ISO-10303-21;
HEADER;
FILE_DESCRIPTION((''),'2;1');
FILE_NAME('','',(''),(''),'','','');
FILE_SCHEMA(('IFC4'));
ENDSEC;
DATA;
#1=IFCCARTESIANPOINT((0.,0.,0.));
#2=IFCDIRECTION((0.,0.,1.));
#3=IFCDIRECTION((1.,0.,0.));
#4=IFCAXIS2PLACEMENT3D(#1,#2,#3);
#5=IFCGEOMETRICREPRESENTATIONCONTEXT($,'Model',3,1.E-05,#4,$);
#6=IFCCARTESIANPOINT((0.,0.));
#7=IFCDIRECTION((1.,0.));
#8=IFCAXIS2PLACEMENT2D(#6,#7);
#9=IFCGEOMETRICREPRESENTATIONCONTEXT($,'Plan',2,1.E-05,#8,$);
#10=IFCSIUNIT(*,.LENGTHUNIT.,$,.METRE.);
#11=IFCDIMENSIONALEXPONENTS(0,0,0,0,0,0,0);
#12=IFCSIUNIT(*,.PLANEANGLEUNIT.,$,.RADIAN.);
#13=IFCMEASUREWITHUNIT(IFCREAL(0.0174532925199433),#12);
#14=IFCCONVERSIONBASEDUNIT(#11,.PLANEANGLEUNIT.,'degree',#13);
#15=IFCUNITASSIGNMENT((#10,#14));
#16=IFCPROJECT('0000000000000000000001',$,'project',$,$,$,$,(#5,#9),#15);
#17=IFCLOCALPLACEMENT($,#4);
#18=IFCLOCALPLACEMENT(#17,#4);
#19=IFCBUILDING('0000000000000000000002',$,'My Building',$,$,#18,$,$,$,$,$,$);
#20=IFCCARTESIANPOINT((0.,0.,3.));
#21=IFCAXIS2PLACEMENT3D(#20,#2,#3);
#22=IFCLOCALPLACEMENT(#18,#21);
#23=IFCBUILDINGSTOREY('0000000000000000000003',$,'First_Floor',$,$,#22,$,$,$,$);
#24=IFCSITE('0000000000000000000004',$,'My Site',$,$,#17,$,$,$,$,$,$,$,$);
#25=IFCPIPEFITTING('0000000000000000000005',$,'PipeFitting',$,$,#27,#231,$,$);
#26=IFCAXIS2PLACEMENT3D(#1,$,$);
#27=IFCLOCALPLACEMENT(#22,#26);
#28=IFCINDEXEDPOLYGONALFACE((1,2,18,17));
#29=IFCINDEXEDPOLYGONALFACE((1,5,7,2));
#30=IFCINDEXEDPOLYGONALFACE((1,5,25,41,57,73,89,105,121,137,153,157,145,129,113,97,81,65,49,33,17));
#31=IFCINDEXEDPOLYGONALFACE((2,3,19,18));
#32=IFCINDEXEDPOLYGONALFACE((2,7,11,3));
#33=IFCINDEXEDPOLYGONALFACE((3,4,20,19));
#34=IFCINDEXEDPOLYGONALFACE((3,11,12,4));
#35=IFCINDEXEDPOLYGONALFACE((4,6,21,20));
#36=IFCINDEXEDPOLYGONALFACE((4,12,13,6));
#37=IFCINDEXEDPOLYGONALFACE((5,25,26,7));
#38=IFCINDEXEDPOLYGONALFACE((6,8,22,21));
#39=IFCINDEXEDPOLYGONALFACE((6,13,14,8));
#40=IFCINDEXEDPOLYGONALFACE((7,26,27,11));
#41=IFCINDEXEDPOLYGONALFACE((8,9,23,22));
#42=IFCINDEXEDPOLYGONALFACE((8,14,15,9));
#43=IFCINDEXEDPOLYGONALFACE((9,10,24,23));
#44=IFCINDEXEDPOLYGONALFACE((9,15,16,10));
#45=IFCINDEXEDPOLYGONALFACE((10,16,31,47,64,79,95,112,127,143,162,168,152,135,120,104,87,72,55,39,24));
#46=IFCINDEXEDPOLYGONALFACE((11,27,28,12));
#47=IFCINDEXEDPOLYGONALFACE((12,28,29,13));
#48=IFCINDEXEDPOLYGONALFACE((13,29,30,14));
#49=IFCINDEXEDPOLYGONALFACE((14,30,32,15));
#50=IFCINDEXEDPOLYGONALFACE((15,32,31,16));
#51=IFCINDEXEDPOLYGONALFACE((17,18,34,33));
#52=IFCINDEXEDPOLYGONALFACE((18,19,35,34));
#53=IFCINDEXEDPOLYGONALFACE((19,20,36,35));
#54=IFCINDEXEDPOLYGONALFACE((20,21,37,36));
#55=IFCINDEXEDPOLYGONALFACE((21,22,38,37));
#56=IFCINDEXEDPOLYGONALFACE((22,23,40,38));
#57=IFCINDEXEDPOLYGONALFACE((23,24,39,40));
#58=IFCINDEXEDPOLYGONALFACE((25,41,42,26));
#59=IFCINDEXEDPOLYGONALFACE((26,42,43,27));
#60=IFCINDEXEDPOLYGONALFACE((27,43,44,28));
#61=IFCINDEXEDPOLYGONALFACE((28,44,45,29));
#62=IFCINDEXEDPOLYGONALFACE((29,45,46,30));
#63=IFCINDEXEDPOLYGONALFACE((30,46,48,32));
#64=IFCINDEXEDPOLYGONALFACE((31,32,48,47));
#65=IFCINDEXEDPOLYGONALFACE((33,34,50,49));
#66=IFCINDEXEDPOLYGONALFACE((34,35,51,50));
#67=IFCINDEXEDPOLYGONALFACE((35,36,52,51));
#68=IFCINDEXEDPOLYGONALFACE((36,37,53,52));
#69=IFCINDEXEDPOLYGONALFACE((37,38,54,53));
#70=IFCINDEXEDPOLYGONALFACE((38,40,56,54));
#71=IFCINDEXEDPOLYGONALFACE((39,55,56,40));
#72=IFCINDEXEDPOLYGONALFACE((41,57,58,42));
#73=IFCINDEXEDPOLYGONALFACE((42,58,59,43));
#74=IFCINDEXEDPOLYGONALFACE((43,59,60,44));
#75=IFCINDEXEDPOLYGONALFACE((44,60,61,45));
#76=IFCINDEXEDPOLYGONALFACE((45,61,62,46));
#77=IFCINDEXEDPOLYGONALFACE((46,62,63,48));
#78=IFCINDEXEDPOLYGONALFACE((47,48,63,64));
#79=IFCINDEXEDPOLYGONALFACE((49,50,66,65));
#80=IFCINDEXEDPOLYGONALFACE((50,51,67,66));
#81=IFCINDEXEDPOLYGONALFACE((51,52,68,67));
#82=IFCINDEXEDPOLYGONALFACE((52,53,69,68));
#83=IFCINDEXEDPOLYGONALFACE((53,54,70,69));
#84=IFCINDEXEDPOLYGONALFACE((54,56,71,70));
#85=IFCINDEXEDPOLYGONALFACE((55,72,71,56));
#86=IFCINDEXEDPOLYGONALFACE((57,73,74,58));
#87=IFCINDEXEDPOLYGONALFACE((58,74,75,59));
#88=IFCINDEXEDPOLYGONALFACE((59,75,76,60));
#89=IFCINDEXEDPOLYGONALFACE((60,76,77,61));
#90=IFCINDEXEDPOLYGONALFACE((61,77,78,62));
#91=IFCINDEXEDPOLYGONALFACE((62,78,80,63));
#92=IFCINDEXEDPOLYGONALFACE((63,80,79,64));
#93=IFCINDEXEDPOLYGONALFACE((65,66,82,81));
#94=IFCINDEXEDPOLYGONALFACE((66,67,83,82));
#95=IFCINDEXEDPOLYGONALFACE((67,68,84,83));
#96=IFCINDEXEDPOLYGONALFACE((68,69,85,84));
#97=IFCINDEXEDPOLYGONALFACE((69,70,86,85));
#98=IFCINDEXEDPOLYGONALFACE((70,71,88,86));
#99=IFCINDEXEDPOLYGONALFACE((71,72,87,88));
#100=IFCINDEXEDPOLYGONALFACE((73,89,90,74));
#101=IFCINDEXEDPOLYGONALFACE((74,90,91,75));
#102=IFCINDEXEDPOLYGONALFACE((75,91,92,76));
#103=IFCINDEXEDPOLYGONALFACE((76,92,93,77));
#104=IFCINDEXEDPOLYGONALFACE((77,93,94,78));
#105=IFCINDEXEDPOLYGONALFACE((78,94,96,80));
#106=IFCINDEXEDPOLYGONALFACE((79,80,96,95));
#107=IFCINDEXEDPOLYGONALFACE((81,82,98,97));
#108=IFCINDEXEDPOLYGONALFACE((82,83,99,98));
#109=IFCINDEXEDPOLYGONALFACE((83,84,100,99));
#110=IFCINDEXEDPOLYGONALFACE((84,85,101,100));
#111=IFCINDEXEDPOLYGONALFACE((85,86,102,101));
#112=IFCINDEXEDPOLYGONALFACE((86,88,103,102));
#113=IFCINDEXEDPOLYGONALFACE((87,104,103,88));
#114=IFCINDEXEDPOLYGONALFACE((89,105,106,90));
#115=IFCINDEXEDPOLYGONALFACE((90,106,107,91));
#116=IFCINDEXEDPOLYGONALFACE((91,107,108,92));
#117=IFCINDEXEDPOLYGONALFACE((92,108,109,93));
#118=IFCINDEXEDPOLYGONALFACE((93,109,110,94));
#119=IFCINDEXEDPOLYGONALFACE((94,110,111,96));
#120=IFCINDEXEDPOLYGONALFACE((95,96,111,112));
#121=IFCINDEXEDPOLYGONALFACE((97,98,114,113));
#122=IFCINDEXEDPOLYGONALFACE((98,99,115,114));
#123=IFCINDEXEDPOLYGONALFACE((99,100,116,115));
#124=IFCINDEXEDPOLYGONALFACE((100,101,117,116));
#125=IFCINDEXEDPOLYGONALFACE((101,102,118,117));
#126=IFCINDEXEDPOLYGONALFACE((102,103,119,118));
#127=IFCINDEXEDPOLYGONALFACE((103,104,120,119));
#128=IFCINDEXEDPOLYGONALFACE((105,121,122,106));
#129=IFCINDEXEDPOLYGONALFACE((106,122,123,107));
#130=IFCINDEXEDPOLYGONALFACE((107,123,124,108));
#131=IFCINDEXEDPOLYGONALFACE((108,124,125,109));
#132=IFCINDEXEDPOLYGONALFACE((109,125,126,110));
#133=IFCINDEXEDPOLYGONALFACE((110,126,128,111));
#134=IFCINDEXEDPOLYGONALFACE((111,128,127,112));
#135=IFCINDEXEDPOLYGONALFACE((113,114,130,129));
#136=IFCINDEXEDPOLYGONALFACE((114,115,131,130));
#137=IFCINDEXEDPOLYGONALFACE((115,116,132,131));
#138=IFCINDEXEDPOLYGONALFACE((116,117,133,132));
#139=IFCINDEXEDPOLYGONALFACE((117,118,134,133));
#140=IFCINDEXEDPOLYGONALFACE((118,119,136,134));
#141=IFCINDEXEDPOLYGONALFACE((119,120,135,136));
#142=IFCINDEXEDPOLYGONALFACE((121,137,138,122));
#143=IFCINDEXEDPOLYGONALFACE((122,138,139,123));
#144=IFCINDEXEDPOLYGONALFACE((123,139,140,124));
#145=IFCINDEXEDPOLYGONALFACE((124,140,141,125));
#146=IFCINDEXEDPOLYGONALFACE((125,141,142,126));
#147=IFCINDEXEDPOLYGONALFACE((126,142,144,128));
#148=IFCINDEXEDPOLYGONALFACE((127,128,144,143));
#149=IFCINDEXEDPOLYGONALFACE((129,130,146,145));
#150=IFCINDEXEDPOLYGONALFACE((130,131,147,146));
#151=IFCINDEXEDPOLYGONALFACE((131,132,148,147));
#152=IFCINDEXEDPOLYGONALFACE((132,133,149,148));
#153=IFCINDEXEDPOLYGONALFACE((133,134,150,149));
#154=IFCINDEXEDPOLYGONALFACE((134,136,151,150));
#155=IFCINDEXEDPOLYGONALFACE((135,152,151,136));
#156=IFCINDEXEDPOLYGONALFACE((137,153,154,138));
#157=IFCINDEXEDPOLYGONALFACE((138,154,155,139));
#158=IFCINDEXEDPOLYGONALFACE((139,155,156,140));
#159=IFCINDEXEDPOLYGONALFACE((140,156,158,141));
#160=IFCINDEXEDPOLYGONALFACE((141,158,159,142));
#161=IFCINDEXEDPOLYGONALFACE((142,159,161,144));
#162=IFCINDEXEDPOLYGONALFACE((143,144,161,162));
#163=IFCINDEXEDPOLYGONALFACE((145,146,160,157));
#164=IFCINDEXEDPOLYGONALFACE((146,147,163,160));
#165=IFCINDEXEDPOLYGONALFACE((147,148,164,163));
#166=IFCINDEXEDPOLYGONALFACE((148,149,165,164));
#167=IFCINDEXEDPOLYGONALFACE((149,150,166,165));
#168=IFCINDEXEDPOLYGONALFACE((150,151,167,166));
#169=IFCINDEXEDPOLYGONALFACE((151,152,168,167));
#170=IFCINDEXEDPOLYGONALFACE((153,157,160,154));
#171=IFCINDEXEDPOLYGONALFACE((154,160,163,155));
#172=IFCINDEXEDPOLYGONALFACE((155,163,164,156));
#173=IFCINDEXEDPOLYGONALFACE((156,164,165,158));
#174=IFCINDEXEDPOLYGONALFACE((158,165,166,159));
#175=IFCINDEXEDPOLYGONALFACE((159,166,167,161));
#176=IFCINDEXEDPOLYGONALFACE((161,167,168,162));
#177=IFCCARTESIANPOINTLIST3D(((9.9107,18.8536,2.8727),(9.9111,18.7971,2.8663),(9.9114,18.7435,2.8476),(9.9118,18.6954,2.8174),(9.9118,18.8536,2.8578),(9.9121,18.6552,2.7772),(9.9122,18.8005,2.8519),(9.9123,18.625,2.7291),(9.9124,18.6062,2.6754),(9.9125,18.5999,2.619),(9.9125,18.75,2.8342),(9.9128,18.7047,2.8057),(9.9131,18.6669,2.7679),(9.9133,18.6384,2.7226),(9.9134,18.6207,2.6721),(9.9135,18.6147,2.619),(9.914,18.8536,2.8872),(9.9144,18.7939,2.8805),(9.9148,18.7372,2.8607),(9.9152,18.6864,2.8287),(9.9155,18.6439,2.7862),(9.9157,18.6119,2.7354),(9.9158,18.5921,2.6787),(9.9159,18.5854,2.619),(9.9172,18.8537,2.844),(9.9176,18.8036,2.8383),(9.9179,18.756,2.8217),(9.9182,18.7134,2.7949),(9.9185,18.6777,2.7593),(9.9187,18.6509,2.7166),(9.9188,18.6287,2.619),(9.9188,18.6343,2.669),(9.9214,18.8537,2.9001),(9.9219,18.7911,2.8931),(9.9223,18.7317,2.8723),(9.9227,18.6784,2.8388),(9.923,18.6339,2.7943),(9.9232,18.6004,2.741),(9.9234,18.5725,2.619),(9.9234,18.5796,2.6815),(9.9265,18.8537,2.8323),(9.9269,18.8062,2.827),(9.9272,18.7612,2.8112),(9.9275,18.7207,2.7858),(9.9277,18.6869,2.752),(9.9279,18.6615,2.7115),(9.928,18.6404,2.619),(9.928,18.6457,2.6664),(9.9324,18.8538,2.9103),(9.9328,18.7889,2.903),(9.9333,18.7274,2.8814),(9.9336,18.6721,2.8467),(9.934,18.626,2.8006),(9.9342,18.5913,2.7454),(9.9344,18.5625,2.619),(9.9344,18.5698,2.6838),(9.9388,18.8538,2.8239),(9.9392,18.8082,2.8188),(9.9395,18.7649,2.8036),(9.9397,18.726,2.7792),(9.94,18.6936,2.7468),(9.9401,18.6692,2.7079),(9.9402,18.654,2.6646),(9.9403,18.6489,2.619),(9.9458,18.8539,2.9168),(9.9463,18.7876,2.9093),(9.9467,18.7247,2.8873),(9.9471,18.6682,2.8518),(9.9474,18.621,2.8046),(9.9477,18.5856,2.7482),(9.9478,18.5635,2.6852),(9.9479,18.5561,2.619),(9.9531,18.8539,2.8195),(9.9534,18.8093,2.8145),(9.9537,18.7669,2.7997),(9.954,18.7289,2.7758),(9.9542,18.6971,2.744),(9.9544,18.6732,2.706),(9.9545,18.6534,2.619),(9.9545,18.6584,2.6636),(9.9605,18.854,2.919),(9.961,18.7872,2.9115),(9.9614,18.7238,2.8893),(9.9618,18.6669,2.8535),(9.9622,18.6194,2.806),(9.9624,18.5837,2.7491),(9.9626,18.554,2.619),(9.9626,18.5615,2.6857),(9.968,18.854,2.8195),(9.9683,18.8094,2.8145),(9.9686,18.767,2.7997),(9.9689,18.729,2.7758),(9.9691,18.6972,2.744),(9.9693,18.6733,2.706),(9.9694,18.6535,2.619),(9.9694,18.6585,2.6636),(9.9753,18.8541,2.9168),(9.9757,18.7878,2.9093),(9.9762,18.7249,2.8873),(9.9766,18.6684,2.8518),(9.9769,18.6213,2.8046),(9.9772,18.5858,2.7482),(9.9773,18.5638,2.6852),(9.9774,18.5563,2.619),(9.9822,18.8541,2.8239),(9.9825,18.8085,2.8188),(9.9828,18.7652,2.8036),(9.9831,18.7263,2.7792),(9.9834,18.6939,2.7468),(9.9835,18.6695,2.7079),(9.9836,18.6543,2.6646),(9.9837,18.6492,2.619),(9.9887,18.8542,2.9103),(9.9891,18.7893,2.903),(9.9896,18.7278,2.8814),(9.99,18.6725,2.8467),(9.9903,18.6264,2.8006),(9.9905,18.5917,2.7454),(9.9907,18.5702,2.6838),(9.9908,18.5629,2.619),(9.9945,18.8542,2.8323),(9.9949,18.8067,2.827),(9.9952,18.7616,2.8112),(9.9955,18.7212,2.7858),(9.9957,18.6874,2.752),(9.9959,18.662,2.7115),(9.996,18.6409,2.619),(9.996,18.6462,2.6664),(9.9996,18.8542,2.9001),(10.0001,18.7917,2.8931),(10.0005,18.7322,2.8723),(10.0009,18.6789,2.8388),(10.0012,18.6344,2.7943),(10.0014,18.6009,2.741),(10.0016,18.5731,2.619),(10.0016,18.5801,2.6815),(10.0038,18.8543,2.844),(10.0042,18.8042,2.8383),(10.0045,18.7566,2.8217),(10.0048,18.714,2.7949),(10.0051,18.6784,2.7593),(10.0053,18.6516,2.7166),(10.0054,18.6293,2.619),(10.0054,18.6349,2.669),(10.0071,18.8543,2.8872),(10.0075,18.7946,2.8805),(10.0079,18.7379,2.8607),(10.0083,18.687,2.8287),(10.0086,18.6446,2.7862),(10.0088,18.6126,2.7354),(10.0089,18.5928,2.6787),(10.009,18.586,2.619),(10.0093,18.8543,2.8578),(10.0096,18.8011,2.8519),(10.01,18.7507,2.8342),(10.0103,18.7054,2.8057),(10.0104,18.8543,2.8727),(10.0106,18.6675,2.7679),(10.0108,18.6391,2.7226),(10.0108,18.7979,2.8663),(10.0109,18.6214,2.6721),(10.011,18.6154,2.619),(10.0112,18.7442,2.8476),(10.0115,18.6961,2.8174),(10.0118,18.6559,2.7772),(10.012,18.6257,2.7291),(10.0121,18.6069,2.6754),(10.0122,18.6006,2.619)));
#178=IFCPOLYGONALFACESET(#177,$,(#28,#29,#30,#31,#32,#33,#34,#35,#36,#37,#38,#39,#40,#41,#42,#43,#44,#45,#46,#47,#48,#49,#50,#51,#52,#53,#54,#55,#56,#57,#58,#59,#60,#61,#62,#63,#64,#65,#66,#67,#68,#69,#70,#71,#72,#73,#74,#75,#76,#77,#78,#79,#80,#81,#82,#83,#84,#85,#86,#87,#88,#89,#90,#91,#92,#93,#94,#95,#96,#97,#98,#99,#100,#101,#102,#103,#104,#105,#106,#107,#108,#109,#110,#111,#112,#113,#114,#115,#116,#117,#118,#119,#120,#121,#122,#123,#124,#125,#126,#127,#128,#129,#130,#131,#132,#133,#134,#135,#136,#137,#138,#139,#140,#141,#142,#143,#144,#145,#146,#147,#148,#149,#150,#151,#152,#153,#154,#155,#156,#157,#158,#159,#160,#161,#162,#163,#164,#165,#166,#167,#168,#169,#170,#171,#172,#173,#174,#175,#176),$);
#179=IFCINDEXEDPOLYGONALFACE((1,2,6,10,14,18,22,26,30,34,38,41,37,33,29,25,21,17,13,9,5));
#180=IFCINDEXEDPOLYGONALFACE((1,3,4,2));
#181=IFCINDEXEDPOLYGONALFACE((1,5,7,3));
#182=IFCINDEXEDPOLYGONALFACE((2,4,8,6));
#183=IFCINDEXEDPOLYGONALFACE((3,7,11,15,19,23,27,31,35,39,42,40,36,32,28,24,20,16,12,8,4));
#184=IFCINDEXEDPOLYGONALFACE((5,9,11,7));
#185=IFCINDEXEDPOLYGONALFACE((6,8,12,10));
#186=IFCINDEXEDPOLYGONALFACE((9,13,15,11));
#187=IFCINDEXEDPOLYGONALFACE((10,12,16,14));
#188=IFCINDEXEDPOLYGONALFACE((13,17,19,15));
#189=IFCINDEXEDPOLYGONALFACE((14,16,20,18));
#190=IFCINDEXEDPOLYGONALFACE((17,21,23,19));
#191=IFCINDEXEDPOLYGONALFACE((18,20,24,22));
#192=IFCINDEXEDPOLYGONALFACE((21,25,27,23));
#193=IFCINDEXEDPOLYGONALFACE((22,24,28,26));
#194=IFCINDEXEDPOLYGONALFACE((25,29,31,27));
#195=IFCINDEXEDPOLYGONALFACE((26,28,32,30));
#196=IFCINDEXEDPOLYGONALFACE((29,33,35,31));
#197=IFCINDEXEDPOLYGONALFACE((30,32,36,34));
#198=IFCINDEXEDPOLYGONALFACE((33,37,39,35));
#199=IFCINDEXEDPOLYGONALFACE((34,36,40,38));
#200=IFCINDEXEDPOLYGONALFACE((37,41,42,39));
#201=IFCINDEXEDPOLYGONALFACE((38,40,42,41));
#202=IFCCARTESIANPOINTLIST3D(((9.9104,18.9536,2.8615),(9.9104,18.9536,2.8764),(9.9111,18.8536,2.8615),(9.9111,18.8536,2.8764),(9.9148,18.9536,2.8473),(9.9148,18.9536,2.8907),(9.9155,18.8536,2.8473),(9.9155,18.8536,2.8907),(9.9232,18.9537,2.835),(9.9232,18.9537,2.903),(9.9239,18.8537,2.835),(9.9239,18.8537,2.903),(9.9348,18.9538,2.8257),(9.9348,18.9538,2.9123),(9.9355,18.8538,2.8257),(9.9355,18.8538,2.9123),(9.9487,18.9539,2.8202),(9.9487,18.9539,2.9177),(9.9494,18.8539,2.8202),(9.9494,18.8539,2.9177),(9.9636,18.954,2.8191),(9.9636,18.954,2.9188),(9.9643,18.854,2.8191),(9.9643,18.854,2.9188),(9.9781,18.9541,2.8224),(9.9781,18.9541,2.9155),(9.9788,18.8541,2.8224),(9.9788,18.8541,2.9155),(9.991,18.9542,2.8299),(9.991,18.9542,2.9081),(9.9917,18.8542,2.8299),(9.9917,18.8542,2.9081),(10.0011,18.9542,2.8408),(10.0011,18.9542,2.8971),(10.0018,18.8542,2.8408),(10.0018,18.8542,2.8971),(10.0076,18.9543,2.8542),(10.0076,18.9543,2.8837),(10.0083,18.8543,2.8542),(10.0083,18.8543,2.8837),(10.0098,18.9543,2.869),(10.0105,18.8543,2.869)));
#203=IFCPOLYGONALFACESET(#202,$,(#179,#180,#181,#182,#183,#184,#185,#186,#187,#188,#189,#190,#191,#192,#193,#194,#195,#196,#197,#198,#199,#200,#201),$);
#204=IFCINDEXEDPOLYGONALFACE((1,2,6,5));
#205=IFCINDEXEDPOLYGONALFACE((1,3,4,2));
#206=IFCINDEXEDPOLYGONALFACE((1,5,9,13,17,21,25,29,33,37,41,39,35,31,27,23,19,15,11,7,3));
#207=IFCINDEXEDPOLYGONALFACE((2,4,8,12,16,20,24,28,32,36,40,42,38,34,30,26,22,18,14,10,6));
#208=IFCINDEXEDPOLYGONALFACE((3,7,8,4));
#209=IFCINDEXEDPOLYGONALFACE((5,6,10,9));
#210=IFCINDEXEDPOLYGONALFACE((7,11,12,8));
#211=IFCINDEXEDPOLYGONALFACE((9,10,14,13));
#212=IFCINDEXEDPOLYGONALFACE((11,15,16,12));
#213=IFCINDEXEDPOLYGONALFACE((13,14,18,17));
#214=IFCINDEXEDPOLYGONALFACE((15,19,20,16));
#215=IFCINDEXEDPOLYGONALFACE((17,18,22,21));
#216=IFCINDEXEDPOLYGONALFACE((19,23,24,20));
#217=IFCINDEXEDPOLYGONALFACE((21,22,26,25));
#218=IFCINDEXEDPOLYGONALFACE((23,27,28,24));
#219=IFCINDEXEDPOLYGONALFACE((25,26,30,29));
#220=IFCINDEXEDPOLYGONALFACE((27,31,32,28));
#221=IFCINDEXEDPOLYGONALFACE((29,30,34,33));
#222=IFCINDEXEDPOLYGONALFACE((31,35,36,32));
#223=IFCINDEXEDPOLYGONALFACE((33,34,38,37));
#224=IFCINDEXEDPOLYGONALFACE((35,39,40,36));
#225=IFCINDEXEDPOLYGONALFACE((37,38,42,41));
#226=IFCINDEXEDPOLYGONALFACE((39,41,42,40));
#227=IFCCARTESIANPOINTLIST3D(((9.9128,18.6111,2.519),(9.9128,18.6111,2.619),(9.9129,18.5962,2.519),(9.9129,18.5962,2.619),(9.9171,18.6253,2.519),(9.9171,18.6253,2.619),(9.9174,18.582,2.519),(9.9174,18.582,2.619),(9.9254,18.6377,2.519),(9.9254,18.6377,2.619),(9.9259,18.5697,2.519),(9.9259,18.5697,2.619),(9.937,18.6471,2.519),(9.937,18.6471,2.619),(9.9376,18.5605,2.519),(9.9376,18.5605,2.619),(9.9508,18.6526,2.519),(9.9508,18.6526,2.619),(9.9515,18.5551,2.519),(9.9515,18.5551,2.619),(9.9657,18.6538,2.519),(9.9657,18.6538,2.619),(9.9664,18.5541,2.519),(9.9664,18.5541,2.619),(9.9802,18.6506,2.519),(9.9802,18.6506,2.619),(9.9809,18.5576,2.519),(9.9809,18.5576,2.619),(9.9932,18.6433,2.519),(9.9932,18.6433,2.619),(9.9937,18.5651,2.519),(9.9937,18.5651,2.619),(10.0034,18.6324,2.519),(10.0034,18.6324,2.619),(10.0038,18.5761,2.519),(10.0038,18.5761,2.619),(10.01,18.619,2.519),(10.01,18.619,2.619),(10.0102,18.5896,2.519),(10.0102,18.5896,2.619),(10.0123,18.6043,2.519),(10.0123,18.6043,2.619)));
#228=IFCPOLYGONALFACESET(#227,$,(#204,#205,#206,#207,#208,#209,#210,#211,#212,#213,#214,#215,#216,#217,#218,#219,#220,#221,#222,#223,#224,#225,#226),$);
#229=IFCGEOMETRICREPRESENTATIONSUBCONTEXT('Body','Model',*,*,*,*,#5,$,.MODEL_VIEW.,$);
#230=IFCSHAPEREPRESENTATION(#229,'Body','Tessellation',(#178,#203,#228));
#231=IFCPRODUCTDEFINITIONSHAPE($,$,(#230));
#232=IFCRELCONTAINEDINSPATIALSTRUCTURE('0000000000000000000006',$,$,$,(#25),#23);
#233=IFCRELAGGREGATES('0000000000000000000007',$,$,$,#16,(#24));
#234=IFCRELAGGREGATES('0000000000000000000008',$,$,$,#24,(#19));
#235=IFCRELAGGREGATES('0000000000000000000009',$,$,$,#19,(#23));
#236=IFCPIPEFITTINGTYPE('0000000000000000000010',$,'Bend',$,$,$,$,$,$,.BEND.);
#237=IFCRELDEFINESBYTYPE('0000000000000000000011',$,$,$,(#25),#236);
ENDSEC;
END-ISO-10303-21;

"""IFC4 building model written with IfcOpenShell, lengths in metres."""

from ifc_helpers import new_model, entity, si_unit, converted_unit, frame, origin_with_axes, origin_2d_with_axis, place, context, subcontext, project, spatial, circle, extrude, source, transform, mapped, type_object, type_shapes, element, save


model = new_model("IFC4")

# Units and contexts
model_context = context("Model", 3, precision=1e-05, world=origin_with_axes())
plan_context = context("Plan", 2, precision=1e-05, world=origin_2d_with_axis())
body_context_1 = subcontext(model_context, "Body", "Model", "MODEL_VIEW")
ifc_project = project(units=[si_unit("LENGTHUNIT", "METRE"), converted_unit("PLANEANGLEUNIT", "degree", entity("IfcReal", 0.0174532925199433), si_unit("PLANEANGLEUNIT", "RADIAN"), dimensions=[0, 0, 0, 0, 0, 0, 0])], contexts=[model_context, plan_context])

# Site, building, storey
site_placement = place(None, origin_with_axes())
site = spatial("IfcSite", under=ifc_project, at=site_placement, Name="My Site")
building_placement = place(site_placement, origin_with_axes())
building = spatial("IfcBuilding", under=site, at=building_placement, Name="My Building")
storey_placement = place(building_placement, frame((0.0, 0.0, 3.0), z_axis=(0.0, 0.0, 1.0), x_axis=(1.0, 0.0, 0.0)))
storey = spatial("IfcBuildingStorey", under=building, at=storey_placement, Name="First_Floor")

# Pipe fitting
pipe_fitting_type = type_object("IfcPipeFittingType", Name="Bend", PredefinedType="BEND")
shared_shape_1 = source(origin_with_axes(), body_context_1, "Body", "SolidModel", [
    entity("IfcSweptDiskSolid", entity("IfcIndexedPolyCurve", entity("IfcCartesianPointList3D", [[0.0, 0.0, -0.1], [0.0, 0.0732, -0.2768], [0.0, 0.25, -0.35]]), [entity("IfcArcIndex", [1, 2, 3])]), 0.05),
    extrude(circle(Radius=0.05), origin_with_axes(), (0.0, 0.0, -1.0), 0.1),
    extrude(circle(Radius=0.05), frame((0.0, 0.25, -0.35), z_axis=(0.0, 1.0, 0.0), x_axis=(1.0, 0.0, 0.0)), (0.0, 0.0, 1.0), 0.1),
])
type_shapes(pipe_fitting_type, [shared_shape_1])
for number, where, z_axis, x_axis, name in (
    (1, (9.9598, 18.954, 2.869), (-0.007084, 0.999975, 0.0), (0.999975, 0.007084, 0.0), "PipeFitting"),
):
    element("IfcPipeFitting", number, at=place(storey_placement, frame(where, z_axis=z_axis, x_axis=x_axis)), inside=storey, type_object=pipe_fitting_type, Name=name, context=body_context_1, shape_type="MappedRepresentation", body=[
        mapped(shared_shape_1, transform((0.0, 0.0, 0.0), x_axis=(1.0, 0.0, 0.0), y_axis=(0.0, 1.0, 0.0), z_axis=(0.0, 0.0, 1.0), scale=1.0)),
    ])

save(model, "model.ifc")
